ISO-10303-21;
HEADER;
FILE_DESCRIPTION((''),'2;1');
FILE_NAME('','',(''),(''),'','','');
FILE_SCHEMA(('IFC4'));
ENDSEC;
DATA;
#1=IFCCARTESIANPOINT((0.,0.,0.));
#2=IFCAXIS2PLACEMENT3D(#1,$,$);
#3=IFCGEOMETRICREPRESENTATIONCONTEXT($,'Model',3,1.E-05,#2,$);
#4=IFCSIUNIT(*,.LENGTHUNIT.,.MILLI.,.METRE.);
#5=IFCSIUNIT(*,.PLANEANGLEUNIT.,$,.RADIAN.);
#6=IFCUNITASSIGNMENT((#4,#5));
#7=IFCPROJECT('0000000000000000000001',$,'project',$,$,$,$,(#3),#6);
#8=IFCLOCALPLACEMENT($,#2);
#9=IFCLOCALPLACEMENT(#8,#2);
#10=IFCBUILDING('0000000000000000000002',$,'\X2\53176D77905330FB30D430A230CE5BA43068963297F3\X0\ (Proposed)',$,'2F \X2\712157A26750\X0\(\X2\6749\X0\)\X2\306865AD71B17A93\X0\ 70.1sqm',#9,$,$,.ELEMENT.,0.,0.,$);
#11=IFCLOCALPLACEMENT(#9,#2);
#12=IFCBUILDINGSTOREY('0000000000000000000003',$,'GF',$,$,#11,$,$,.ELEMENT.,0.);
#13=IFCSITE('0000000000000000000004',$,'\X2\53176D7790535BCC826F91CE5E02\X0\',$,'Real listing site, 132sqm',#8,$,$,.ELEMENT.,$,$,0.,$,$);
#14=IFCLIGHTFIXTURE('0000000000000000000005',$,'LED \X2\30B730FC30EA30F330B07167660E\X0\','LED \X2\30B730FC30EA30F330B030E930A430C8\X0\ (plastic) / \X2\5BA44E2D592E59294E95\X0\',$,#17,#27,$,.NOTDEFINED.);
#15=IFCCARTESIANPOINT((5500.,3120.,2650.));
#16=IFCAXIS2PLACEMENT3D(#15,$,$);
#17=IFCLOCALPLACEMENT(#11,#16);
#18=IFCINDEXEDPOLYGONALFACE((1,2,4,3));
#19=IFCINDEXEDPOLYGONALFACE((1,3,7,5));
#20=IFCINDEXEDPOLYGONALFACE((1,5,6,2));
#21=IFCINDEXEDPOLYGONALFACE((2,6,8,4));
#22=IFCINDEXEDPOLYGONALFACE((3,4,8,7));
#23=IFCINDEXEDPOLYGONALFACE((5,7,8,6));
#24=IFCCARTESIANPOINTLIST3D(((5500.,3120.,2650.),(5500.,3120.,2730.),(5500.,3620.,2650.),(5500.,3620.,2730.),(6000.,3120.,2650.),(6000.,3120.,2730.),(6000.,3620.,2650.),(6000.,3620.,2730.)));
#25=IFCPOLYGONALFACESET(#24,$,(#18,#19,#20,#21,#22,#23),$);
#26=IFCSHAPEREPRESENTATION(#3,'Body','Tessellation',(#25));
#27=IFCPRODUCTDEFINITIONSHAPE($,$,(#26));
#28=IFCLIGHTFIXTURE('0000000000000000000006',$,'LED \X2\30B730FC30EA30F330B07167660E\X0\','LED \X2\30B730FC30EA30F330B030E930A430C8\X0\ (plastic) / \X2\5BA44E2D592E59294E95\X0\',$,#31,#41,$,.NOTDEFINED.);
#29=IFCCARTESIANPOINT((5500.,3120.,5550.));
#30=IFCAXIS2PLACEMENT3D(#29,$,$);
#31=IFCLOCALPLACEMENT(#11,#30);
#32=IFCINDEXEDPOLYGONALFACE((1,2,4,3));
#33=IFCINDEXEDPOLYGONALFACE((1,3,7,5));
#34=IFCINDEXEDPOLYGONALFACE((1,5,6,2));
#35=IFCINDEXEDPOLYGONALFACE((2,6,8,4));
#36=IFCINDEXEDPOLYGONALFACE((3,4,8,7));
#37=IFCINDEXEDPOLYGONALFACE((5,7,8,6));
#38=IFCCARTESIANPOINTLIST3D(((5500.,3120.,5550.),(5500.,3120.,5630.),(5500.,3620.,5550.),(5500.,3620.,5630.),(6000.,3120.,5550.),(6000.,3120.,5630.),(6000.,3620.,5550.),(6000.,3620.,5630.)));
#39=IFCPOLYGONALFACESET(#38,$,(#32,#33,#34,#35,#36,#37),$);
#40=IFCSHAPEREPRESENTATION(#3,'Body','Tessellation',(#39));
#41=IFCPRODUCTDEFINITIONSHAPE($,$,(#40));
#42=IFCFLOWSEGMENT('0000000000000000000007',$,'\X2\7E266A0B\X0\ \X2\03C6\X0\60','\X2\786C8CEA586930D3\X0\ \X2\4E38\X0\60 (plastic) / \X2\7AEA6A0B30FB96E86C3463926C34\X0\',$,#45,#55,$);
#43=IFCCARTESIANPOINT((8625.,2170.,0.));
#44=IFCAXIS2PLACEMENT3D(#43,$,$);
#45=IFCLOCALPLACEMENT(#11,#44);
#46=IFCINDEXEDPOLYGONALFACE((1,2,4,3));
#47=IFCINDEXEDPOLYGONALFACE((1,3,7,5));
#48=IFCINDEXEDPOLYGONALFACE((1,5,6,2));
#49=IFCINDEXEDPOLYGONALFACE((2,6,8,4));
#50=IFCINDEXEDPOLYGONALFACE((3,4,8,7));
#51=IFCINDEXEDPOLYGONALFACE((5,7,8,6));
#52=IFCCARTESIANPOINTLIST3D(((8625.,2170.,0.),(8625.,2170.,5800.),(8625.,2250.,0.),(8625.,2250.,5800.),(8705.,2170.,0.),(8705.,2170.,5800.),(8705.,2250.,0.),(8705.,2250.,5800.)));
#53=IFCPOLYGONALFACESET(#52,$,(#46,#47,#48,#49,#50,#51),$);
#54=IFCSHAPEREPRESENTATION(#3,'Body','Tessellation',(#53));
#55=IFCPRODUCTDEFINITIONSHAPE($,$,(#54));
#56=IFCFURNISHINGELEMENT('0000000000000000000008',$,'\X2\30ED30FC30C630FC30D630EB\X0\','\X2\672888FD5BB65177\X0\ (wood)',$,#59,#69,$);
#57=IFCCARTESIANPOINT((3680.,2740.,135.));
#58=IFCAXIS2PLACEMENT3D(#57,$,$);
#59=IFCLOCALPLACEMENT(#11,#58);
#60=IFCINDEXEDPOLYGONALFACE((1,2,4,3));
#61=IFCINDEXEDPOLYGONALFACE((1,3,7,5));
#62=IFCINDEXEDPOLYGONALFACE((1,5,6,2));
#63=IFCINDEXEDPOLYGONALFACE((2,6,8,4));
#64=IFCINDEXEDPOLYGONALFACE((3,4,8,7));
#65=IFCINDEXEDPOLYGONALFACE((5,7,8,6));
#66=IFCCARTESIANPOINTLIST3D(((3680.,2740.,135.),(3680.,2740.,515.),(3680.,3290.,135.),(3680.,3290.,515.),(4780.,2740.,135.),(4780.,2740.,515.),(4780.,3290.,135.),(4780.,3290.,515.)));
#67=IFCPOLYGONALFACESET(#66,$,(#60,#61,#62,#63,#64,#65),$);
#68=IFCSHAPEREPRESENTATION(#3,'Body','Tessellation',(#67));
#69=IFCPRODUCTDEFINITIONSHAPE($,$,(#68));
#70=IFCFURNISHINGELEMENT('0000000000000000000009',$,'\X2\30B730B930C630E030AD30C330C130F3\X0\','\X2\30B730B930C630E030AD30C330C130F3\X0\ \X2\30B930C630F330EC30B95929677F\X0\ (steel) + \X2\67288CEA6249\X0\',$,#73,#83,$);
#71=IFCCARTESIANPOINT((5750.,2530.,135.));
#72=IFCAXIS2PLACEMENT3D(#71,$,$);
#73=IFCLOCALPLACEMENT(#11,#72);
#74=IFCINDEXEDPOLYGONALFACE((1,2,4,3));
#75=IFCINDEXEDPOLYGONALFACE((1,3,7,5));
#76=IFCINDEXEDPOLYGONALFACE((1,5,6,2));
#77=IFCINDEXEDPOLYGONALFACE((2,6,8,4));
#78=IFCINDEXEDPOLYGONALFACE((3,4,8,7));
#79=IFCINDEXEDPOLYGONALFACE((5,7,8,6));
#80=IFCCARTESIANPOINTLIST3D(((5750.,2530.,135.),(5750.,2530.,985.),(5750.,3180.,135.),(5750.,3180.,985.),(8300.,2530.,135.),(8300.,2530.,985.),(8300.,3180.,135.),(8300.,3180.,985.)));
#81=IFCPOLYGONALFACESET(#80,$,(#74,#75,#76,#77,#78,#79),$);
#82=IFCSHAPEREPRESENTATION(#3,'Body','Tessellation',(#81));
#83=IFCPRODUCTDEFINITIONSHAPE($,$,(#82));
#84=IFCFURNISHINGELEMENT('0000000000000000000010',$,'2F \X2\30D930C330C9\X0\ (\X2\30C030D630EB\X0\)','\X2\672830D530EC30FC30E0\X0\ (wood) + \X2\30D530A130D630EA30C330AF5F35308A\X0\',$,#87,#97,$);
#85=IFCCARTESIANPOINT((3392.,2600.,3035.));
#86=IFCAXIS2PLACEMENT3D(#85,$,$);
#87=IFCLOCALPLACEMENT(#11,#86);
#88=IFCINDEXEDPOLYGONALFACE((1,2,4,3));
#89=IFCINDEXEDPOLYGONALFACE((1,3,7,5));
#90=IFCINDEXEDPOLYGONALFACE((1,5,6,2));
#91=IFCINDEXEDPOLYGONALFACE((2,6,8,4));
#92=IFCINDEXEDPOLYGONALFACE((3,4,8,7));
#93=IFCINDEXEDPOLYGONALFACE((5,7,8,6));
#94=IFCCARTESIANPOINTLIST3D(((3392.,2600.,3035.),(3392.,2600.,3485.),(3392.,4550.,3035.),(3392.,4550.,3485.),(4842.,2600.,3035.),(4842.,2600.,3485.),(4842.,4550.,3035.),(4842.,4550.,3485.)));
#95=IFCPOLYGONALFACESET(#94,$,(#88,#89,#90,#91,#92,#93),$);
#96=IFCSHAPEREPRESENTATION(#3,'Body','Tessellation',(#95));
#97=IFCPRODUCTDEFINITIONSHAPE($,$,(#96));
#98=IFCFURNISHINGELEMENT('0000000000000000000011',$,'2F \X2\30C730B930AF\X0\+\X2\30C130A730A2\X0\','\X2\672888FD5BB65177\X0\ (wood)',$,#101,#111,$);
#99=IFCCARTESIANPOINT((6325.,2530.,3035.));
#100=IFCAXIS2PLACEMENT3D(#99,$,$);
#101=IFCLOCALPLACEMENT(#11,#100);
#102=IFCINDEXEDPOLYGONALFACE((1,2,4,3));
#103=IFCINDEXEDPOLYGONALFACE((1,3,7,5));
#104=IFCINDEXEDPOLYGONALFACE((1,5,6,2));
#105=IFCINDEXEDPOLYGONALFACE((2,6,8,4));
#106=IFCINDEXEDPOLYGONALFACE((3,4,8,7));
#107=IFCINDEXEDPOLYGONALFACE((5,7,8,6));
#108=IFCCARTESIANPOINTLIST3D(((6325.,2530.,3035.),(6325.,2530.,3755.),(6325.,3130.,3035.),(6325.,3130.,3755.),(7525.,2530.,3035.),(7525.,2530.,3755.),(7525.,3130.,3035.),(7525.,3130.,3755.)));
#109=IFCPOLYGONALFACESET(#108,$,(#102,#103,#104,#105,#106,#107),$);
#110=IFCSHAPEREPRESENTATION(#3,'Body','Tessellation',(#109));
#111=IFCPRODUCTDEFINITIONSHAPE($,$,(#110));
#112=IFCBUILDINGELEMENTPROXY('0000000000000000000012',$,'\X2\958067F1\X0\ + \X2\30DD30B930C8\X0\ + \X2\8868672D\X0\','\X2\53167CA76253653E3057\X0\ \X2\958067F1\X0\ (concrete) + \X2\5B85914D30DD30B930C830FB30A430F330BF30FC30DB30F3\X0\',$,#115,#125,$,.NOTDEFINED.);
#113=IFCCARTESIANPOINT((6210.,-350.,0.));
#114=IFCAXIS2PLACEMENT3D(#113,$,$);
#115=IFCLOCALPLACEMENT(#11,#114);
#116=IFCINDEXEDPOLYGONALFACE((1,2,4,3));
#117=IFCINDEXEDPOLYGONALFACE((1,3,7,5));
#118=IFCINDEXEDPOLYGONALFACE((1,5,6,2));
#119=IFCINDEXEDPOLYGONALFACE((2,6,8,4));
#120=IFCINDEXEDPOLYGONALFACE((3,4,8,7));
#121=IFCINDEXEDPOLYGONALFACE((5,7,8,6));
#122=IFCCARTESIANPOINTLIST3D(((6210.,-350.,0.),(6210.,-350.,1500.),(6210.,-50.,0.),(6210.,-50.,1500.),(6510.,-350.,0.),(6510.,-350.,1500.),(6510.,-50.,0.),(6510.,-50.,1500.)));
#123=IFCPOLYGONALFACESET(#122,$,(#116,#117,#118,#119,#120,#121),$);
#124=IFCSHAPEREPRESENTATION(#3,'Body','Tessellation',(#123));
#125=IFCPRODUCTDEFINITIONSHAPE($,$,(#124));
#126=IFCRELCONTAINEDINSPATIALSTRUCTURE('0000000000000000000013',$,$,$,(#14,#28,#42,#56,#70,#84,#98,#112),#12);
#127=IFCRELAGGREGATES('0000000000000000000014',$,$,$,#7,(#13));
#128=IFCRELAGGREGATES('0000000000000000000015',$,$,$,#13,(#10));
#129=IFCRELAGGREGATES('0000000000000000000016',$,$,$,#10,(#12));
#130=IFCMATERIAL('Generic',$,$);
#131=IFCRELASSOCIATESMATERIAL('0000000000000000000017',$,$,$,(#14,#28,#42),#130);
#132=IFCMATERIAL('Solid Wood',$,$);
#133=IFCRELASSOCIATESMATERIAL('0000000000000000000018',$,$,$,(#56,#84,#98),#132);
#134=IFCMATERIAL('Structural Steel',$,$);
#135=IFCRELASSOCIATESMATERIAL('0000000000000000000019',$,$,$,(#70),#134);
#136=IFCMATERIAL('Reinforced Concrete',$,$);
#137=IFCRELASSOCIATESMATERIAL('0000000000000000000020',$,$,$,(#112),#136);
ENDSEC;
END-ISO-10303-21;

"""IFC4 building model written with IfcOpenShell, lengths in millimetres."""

from ifc_helpers import new_model, si_unit, frame, frame_2d, origin, place, context, project, spatial, rectangle, extrude, material, element, save


model = new_model("IFC4")

# Units and contexts
model_context = context("Model", 3, precision=1e-05, world=origin())
ifc_project = project(units=[si_unit("LENGTHUNIT", "METRE", prefix="MILLI"), si_unit("PLANEANGLEUNIT", "RADIAN")], contexts=[model_context])

# Site, building, storey
site_placement = place(None, origin())
site = spatial("IfcSite", under=ifc_project, at=site_placement, Name="北海道富良野市", ObjectType="Real listing site, 132sqm", CompositionType="ELEMENT", RefElevation=0.0)
building_placement = place(site_placement, origin())
building = spatial("IfcBuilding", under=site, at=building_placement, Name="北海道・ピアノ室と防音 (Proposed)", ObjectType="2F 無垢材(杉)と断熱窓 70.1sqm", CompositionType="ELEMENT", ElevationOfRefHeight=0.0, ElevationOfTerrain=0.0)
storey_placement = place(building_placement, origin())
storey = spatial("IfcBuildingStorey", under=building, at=storey_placement, Name="GF", CompositionType="ELEMENT", Elevation=0.0)

# Shared definitions
ifc_material_1 = material(Name="Solid Wood")

# Shared definitions
ifc_material_2 = material(Name="Reinforced Concrete")

# Shared definitions
ifc_material_3 = material(Name="Structural Steel")

# Shared definitions
ifc_material_4 = material(Name="Generic")

# Light fixtures
light_fixture_1_placement = place(storey_placement, frame((5500.0, 3120.0, 2650.0)))
element("IfcLightFixture", 1, at=light_fixture_1_placement, inside=storey, material=ifc_material_4, Name="LED シーリング照明", Description="LED シーリングライト (plastic) / 室中央天井", PredefinedType="NOTDEFINED", context=model_context, shape_type="SweptSolid", body=[
    extrude(rectangle(XDim=500.0, YDim=500.0, at=frame_2d((250.0, 250.0))), frame((5500.0, 3120.0, 2650.0)), (0.0, 0.0, 1.0), 80.0),
])
light_fixture_2_placement = place(storey_placement, frame((5500.0, 3120.0, 5550.0)))
element("IfcLightFixture", 2, at=light_fixture_2_placement, inside=storey, material=ifc_material_4, Name="LED シーリング照明", Description="LED シーリングライト (plastic) / 室中央天井", PredefinedType="NOTDEFINED", context=model_context, shape_type="SweptSolid", body=[
    extrude(rectangle(XDim=500.0, YDim=500.0, at=frame_2d((250.0, 250.0))), frame((5500.0, 3120.0, 5550.0)), (0.0, 0.0, 1.0), 80.0),
])

# Flow segment
flow_segment_placement = place(storey_placement, frame((8625.0, 2170.0, 0.0)))
element("IfcFlowSegment", 3, at=flow_segment_placement, inside=storey, material=ifc_material_4, Name="縦樋 φ60", Description="硬質塩ビ 丸60 (plastic) / 竪樋・雨水排水", context=model_context, shape_type="SweptSolid", body=[
    extrude(rectangle(XDim=80.0, YDim=80.0, at=frame_2d((40.0, 40.0))), frame((8625.0, 2170.0, 0.0)), (0.0, 0.0, 1.0), 5800.0),
])

# Furnishing elements
furnishing_1_placement = place(storey_placement, frame((3680.0, 2740.0, 135.0)))
element("IfcFurnishingElement", 4, at=furnishing_1_placement, inside=storey, material=ifc_material_1, Name="ローテーブル", Description="木製家具 (wood)", context=model_context, shape_type="SweptSolid", body=[
    extrude(rectangle(XDim=1100.0, YDim=550.0, at=frame_2d((550.0, 275.0))), frame((3680.0, 2740.0, 135.0)), (0.0, 0.0, 1.0), 380.0),
])
furnishing_2_placement = place(storey_placement, frame((5750.0, 2530.0, 135.0)))
element("IfcFurnishingElement", 5, at=furnishing_2_placement, inside=storey, material=ifc_material_3, Name="システムキッチン", Description="システムキッチン ステンレス天板 (steel) + 木質扉", context=model_context, shape_type="SweptSolid", body=[
    extrude(rectangle(XDim=2550.0, YDim=650.0, at=frame_2d((1275.0, 325.0))), frame((5750.0, 2530.0, 135.0)), (0.0, 0.0, 1.0), 850.0),
])
furnishing_3_placement = place(storey_placement, frame((3392.0, 2600.0, 3035.0)))
element("IfcFurnishingElement", 6, at=furnishing_3_placement, inside=storey, material=ifc_material_1, Name="2F ベッド (ダブル)", Description="木フレーム (wood) + ファブリック張り", context=model_context, shape_type="SweptSolid", body=[
    extrude(rectangle(XDim=1450.0, YDim=1950.0, at=frame_2d((725.0, 975.0))), frame((3392.0, 2600.0, 3035.0)), (0.0, 0.0, 1.0), 450.0),
])
furnishing_4_placement = place(storey_placement, frame((6325.0, 2530.0, 3035.0)))
element("IfcFurnishingElement", 7, at=furnishing_4_placement, inside=storey, material=ifc_material_1, Name="2F デスク+チェア", Description="木製家具 (wood)", context=model_context, shape_type="SweptSolid", body=[
    extrude(rectangle(XDim=1200.0, YDim=600.0, at=frame_2d((600.0, 300.0))), frame((6325.0, 2530.0, 3035.0)), (0.0, 0.0, 1.0), 720.0),
])

# Building element proxy
proxy_placement = place(storey_placement, frame((6210.0, -350.0, 0.0)))
element("IfcBuildingElementProxy", 8, at=proxy_placement, inside=storey, material=ifc_material_2, Name="門柱 + ポスト + 表札", Description="化粧打放し 門柱 (concrete) + 宅配ポスト・インターホン", PredefinedType="NOTDEFINED", context=model_context, shape_type="SweptSolid", body=[
    extrude(rectangle(XDim=300.0, YDim=300.0, at=frame_2d((150.0, 150.0))), frame((6210.0, -350.0, 0.0)), (0.0, 0.0, 1.0), 1500.0),
])

save(model, "model.ifc")
